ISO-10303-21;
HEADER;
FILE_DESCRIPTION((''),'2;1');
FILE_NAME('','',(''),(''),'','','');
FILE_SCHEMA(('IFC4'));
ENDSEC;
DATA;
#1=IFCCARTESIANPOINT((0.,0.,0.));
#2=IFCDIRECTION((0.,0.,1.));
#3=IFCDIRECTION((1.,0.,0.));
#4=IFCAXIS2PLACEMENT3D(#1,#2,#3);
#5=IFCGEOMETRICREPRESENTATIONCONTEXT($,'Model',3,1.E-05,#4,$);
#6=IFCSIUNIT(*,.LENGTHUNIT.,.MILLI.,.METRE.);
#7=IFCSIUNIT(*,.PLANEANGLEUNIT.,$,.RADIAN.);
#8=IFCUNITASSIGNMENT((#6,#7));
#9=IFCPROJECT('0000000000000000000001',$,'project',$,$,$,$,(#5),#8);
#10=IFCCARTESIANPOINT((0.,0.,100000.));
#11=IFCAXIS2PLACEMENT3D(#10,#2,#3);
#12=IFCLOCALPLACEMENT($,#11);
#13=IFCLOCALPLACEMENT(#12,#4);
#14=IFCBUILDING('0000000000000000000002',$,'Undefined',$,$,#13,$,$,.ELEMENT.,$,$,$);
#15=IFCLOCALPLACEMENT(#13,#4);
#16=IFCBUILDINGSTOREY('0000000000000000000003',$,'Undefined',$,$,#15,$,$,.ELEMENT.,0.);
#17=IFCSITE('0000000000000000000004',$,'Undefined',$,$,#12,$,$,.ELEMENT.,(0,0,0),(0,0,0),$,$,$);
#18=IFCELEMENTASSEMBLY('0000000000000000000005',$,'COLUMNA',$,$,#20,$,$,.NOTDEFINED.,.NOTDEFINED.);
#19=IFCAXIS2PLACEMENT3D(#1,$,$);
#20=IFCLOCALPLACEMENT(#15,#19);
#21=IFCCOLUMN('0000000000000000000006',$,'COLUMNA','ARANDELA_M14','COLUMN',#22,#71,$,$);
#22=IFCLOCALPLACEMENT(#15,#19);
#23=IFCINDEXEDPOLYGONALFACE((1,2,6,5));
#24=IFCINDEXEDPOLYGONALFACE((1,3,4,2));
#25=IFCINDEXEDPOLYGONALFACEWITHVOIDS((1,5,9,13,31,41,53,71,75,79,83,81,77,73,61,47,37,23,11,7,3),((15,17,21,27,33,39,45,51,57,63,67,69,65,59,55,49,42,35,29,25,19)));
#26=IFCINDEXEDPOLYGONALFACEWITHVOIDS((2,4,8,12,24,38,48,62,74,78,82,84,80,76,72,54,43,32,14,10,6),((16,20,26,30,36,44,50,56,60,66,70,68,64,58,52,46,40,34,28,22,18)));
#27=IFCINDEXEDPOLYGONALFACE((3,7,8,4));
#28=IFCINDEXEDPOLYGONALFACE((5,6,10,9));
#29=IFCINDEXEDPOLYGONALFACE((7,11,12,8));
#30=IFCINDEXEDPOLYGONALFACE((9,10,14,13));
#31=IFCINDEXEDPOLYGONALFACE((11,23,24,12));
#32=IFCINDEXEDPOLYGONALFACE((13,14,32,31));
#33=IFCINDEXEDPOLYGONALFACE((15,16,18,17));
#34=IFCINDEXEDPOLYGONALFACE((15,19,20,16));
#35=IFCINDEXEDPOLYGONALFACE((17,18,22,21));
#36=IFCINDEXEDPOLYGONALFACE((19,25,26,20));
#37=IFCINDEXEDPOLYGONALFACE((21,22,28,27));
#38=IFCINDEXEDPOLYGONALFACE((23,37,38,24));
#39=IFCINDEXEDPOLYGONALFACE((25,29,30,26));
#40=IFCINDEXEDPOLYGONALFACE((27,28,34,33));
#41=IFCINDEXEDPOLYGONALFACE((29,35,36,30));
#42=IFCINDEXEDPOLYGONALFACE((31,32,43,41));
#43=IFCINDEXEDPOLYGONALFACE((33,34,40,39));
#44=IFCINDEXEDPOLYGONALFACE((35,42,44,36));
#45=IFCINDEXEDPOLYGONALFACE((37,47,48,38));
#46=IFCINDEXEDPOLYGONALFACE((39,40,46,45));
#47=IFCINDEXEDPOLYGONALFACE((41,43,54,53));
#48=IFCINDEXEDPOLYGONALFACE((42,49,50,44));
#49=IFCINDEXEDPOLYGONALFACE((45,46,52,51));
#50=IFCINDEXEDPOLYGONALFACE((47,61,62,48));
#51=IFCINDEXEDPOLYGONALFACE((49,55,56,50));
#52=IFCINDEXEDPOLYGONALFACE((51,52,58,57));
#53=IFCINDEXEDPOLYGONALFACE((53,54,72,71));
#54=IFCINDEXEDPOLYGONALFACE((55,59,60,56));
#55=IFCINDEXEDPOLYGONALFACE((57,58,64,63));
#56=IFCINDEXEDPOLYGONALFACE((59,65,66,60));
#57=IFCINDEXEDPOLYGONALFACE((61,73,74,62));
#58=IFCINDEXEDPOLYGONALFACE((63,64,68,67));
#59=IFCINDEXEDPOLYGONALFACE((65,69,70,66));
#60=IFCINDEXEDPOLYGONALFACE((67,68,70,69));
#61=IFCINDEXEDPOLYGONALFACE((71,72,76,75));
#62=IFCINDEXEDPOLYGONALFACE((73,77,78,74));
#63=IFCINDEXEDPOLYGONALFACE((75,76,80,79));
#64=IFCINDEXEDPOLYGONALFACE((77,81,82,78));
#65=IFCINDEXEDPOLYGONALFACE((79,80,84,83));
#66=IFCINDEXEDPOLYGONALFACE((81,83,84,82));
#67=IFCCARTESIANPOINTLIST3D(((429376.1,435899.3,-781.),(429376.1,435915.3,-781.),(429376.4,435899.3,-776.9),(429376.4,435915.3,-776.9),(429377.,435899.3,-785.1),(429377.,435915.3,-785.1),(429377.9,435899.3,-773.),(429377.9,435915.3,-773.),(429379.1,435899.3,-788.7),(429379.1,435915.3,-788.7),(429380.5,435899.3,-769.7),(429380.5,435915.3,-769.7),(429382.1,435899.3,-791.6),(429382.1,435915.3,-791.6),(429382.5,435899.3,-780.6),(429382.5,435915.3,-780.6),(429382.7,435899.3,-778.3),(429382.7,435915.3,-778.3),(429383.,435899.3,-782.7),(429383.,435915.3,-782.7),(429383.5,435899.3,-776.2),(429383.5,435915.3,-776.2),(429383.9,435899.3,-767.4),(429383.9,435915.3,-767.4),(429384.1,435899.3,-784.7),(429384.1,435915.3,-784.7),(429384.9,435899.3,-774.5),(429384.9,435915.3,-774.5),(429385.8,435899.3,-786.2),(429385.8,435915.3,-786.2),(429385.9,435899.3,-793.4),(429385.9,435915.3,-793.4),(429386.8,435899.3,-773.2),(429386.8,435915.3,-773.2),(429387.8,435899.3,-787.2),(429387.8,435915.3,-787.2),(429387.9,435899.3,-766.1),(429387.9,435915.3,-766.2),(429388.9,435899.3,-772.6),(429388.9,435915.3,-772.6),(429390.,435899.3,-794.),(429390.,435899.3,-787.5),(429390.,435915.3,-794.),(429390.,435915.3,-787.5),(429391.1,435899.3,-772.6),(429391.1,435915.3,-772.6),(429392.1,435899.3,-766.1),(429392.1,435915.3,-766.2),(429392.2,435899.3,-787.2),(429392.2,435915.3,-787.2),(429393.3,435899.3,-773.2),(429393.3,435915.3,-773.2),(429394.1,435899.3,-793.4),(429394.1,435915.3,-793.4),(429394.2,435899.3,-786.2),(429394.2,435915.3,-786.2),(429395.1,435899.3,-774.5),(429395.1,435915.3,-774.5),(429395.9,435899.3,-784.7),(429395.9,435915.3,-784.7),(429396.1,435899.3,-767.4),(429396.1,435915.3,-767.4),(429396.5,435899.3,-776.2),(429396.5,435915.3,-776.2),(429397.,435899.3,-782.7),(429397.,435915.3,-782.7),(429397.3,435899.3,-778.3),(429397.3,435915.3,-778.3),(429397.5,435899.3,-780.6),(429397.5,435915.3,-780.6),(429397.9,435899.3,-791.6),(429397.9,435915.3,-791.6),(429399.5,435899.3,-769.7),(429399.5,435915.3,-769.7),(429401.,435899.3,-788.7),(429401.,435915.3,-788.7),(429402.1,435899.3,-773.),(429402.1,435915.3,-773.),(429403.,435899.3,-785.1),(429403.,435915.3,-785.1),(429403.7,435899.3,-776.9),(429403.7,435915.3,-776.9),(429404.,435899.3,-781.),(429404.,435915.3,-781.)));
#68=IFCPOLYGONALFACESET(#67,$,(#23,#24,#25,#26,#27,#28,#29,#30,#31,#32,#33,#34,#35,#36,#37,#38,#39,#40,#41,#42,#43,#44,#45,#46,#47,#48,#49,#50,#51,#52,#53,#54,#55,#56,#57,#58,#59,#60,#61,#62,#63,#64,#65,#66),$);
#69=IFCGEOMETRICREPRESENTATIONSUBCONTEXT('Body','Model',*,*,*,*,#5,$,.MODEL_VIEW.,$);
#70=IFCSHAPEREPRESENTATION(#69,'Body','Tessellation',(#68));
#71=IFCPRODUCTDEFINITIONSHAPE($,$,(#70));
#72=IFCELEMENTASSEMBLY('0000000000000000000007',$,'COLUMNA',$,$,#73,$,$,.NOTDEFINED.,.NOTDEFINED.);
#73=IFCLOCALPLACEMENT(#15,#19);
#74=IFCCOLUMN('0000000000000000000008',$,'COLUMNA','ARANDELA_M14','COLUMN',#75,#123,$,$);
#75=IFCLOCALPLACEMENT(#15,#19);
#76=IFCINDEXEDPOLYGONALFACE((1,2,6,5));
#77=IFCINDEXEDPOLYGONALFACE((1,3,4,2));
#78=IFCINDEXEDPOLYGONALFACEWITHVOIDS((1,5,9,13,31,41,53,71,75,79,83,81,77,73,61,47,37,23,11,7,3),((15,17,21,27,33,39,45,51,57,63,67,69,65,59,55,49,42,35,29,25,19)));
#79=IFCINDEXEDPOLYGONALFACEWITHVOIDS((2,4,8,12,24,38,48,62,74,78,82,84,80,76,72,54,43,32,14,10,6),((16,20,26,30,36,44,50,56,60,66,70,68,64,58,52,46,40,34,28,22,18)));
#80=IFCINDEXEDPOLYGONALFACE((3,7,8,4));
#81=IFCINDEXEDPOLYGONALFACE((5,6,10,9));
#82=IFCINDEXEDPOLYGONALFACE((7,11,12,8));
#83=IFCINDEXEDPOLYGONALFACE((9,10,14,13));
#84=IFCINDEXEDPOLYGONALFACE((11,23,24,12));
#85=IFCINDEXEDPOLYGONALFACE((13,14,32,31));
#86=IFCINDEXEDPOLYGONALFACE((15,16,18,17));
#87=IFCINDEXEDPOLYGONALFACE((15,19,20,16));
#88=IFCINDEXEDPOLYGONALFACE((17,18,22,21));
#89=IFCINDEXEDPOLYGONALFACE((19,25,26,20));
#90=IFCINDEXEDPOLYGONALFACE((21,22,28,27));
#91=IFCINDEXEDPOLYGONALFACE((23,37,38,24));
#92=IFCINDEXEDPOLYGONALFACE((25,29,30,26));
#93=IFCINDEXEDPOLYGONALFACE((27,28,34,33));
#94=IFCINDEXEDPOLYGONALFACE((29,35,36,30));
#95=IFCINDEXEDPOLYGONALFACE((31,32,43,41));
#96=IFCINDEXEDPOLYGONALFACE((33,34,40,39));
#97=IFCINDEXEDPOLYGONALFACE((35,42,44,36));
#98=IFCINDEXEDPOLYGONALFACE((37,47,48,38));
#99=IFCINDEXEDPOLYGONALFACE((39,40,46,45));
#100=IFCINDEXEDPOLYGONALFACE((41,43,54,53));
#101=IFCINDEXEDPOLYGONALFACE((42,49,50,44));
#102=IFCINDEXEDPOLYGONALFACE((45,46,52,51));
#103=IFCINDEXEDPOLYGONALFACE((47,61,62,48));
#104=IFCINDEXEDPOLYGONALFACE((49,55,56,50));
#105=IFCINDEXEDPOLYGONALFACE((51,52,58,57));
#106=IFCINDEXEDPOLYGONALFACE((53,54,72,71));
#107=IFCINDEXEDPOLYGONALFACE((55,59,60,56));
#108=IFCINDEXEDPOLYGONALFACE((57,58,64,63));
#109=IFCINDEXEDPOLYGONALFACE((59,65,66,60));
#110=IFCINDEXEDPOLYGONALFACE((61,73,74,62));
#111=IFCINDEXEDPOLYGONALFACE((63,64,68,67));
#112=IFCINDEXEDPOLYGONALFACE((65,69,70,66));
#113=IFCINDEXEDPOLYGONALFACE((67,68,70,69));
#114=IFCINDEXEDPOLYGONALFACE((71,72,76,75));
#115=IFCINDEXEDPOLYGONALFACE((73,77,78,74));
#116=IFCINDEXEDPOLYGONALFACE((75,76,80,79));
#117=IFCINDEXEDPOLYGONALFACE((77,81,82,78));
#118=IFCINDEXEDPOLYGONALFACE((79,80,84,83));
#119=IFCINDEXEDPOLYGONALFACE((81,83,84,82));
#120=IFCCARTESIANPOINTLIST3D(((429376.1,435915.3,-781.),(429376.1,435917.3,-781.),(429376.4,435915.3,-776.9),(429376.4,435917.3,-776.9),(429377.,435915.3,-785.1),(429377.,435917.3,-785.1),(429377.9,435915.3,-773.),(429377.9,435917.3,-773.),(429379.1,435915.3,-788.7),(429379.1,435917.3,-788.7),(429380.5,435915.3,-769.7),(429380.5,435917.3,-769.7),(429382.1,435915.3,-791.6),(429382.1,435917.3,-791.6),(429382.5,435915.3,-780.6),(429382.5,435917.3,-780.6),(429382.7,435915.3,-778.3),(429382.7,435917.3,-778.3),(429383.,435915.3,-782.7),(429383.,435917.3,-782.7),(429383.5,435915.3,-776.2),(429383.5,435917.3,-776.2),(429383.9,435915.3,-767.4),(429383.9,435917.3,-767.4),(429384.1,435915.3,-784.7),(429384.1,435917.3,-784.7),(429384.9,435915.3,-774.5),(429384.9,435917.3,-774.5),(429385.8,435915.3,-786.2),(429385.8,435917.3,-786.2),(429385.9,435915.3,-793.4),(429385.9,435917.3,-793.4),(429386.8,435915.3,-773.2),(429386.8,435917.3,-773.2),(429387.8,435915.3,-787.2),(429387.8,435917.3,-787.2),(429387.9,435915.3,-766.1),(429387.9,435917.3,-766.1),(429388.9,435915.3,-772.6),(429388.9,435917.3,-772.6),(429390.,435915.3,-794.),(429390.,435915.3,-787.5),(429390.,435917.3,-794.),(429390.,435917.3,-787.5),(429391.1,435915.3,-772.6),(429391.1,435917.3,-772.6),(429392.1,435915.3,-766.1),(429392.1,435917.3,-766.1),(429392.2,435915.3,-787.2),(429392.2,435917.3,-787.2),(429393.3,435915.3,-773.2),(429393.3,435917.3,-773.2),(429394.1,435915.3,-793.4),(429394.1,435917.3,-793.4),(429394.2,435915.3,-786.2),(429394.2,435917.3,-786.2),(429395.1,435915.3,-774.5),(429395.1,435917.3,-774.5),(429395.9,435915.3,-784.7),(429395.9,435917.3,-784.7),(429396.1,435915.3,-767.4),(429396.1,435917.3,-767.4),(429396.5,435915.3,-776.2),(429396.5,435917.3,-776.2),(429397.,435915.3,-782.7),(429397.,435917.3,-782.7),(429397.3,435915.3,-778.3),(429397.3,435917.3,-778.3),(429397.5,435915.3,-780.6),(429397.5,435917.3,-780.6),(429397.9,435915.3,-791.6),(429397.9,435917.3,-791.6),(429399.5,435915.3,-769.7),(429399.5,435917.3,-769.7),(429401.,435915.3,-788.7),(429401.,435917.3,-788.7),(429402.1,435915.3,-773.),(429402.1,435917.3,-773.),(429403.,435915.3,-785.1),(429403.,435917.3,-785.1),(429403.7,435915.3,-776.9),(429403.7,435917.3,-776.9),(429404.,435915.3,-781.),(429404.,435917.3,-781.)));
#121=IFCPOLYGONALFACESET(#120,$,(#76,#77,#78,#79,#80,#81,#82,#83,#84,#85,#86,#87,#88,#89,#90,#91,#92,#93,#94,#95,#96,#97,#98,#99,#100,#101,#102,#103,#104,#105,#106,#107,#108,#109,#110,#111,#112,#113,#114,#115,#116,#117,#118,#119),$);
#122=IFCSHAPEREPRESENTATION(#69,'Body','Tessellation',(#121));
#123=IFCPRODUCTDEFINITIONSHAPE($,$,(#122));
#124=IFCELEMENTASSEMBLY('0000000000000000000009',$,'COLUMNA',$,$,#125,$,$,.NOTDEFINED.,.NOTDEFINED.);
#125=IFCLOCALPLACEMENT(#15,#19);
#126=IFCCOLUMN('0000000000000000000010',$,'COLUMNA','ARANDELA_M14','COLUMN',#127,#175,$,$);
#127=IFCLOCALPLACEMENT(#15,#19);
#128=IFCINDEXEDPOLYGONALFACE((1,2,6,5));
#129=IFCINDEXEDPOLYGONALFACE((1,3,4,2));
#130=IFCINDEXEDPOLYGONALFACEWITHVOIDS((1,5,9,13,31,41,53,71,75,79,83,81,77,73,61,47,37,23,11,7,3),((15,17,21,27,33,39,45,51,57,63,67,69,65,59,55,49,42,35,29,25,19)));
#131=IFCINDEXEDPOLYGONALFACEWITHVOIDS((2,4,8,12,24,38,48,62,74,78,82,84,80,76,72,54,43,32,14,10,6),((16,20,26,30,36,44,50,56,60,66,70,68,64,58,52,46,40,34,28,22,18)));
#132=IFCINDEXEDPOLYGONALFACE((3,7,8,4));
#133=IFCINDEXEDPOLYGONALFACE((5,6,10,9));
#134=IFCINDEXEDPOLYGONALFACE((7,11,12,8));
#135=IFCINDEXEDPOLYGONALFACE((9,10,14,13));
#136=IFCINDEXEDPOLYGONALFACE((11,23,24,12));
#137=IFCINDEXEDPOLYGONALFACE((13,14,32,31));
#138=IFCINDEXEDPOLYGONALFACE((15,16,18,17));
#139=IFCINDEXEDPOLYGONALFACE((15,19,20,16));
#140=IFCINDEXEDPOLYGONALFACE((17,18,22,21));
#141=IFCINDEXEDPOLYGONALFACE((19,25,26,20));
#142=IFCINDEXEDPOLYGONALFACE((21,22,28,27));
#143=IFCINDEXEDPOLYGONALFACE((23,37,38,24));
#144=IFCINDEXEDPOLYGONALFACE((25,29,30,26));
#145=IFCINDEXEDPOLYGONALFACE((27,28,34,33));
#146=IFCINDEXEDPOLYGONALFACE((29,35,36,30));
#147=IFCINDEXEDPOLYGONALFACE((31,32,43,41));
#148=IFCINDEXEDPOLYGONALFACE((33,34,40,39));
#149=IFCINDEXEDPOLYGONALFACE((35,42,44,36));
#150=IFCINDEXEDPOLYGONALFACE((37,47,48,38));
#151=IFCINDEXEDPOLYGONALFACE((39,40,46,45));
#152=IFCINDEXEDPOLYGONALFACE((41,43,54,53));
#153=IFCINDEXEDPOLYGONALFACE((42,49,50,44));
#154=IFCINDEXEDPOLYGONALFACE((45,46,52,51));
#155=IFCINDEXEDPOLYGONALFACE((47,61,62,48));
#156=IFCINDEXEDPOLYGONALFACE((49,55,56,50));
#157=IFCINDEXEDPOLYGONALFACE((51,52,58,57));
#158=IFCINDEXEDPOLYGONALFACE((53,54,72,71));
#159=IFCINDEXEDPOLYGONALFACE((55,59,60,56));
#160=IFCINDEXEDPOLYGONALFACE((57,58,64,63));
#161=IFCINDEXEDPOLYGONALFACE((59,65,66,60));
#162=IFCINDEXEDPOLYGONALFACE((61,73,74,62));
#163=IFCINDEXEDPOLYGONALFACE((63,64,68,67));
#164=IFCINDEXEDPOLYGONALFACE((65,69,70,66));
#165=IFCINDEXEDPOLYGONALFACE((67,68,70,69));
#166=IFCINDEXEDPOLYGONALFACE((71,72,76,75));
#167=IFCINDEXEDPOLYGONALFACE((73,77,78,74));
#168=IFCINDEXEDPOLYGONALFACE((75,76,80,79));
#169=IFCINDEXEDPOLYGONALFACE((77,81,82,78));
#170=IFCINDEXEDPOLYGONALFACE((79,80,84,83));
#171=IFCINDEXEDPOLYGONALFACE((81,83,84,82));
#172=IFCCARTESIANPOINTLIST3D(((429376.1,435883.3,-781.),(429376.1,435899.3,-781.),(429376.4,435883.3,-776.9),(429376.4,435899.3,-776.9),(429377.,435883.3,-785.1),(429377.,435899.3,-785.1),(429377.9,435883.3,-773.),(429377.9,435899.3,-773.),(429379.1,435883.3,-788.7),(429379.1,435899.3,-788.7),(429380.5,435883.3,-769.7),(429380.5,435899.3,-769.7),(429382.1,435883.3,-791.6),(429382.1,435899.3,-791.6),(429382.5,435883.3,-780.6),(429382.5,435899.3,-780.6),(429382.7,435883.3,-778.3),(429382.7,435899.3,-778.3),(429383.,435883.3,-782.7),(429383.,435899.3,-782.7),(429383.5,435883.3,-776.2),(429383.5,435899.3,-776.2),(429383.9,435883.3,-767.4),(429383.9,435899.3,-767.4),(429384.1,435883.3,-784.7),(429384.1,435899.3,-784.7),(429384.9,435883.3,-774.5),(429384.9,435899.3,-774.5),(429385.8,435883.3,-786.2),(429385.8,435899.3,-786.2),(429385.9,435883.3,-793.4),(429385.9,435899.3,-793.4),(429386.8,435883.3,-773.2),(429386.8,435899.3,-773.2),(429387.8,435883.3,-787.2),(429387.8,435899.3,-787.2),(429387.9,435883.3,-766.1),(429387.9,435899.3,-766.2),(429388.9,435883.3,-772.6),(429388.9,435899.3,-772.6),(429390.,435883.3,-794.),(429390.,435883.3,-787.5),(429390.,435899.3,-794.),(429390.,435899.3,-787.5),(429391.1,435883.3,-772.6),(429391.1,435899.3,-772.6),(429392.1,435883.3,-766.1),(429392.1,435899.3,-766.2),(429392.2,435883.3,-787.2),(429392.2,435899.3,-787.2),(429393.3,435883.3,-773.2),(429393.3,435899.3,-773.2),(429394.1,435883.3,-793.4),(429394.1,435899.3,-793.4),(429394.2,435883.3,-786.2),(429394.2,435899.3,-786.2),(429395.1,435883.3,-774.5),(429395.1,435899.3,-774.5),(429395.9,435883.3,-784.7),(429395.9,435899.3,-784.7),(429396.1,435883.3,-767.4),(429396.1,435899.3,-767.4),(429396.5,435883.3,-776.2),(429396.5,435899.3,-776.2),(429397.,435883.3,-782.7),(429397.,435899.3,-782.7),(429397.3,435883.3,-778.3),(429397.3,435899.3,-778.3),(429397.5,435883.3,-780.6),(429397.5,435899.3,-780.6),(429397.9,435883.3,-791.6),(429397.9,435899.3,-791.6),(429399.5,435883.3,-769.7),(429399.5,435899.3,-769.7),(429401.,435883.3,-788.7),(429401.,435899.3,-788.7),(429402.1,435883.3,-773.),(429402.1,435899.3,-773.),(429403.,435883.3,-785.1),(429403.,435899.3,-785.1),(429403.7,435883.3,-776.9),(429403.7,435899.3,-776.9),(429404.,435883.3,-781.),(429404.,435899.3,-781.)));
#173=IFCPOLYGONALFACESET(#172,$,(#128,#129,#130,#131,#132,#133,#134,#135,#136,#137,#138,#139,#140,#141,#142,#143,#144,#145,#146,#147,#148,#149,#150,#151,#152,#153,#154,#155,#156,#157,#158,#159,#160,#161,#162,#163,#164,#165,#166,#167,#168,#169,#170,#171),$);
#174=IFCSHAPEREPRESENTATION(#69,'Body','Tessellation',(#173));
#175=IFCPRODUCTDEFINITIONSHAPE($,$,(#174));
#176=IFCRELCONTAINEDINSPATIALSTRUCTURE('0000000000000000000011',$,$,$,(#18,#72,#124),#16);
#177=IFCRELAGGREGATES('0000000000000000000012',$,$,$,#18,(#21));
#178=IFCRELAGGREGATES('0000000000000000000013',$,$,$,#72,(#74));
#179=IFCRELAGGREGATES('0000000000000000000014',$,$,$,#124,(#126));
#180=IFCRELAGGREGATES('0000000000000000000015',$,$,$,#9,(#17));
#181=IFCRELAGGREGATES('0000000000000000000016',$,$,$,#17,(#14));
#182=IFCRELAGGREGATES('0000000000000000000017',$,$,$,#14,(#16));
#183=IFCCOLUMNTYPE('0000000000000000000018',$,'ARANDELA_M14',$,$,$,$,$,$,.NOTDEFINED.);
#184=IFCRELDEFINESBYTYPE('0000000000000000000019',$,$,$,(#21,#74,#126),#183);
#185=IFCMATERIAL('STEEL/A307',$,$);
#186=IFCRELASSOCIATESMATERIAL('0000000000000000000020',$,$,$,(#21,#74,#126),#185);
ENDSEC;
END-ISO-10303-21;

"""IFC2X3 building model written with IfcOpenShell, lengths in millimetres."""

from ifc_helpers import new_model, si_unit, frame, origin_with_axes, origin_2d_with_axis, place, context, subcontext, project, spatial, hollow_circle, extrude, material, type_object, element, aggregate, save


model = new_model("IFC2X3")

# Units and contexts
model_context = context("Model", 3, precision=1e-05, world=origin_with_axes())
body_context = subcontext(model_context, "Body", "Model", "MODEL_VIEW")
ifc_project = project(units=[si_unit("LENGTHUNIT", "METRE", prefix="MILLI"), si_unit("PLANEANGLEUNIT", "RADIAN")], contexts=[model_context])

# Site, building, storey
site_placement = place(None, frame((0.0, 0.0, 100000.0), z_axis=(0.0, 0.0, 1.0), x_axis=(1.0, 0.0, 0.0)))
site = spatial("IfcSite", under=ifc_project, at=site_placement, Name="Undefined", CompositionType="ELEMENT", RefLatitude=(0, 0, 0), RefLongitude=(0, 0, 0))
building_placement = place(site_placement, origin_with_axes())
building = spatial("IfcBuilding", under=site, at=building_placement, Name="Undefined", CompositionType="ELEMENT")
storey_placement = place(building_placement, origin_with_axes())
storey = spatial("IfcBuildingStorey", under=building, at=storey_placement, Name="Undefined", CompositionType="ELEMENT", Elevation=0.0)

# Element assemblies, columns
ifc_material_1 = material(Name="STEEL/A307")
column_type = type_object("IfcColumnType", Name="ARANDELA_M14", PredefinedType="NOTDEFINED")
assembly_1_placement = place(storey_placement, origin_with_axes())
assembly_1 = element("IfcElementAssembly", 1, at=assembly_1_placement, inside=storey, Name="COLUMNA", AssemblyPlace="NOTDEFINED", PredefinedType="NOTDEFINED")
column_1_placement = place(assembly_1_placement, frame((429390.0, 435915.3, -780.0), z_axis=(0.0, -1.0, 0.000285), x_axis=(-1.0, 0.0, 0.0)))
column_1 = element("IfcColumn", 2, at=column_1_placement, type_object=column_type, material=ifc_material_1, Name="COLUMNA", Description="ARANDELA_M14", ObjectType="COLUMN", context=body_context, shape_type="SweptSolid", body=[
    extrude(hollow_circle(Radius=14.0, WallThickness=6.5, at=origin_2d_with_axis()), frame((0.0, 0.0, 16.0), z_axis=(0.0, 0.0, -1.0), x_axis=(0.0, 1.0, 0.0)), (0.0, 0.0, 1.0), 16.0),
])
aggregate(assembly_1, [column_1])
assembly_2_placement = place(storey_placement, origin_with_axes())
assembly_2 = element("IfcElementAssembly", 3, at=assembly_2_placement, inside=storey, Name="COLUMNA", AssemblyPlace="NOTDEFINED", PredefinedType="NOTDEFINED")
column_2_placement = place(assembly_2_placement, frame((429390.0, 435917.3, -780.0), z_axis=(0.0, -1.0, 0.000285), x_axis=(-1.0, 0.0, 0.0)))
column_2 = element("IfcColumn", 4, at=column_2_placement, type_object=column_type, material=ifc_material_1, Name="COLUMNA", Description="ARANDELA_M14", ObjectType="COLUMN", context=body_context, shape_type="SweptSolid", body=[
    extrude(hollow_circle(Radius=14.0, WallThickness=6.5, at=origin_2d_with_axis()), frame((0.0, 0.0, 2.0), z_axis=(0.0, 0.0, -1.0), x_axis=(0.0, 1.0, 0.0)), (0.0, 0.0, 1.0), 2.0),
])
aggregate(assembly_2, [column_2])
assembly_3_placement = place(storey_placement, origin_with_axes())
assembly_3 = element("IfcElementAssembly", 5, at=assembly_3_placement, inside=storey, Name="COLUMNA", AssemblyPlace="NOTDEFINED", PredefinedType="NOTDEFINED")
column_3_placement = place(assembly_3_placement, frame((429390.0, 435899.3, -780.0), z_axis=(0.0, -1.0, 0.000285), x_axis=(-1.0, 0.0, 0.0)))
column_3 = element("IfcColumn", 6, at=column_3_placement, type_object=column_type, material=ifc_material_1, Name="COLUMNA", Description="ARANDELA_M14", ObjectType="COLUMN", context=body_context, shape_type="SweptSolid", body=[
    extrude(hollow_circle(Radius=14.0, WallThickness=6.5, at=origin_2d_with_axis()), frame((0.0, 0.0, 16.0), z_axis=(0.0, 0.0, -1.0), x_axis=(0.0, 1.0, 0.0)), (0.0, 0.0, 1.0), 16.0),
])
aggregate(assembly_3, [column_3])

save(model, "model.ifc")
